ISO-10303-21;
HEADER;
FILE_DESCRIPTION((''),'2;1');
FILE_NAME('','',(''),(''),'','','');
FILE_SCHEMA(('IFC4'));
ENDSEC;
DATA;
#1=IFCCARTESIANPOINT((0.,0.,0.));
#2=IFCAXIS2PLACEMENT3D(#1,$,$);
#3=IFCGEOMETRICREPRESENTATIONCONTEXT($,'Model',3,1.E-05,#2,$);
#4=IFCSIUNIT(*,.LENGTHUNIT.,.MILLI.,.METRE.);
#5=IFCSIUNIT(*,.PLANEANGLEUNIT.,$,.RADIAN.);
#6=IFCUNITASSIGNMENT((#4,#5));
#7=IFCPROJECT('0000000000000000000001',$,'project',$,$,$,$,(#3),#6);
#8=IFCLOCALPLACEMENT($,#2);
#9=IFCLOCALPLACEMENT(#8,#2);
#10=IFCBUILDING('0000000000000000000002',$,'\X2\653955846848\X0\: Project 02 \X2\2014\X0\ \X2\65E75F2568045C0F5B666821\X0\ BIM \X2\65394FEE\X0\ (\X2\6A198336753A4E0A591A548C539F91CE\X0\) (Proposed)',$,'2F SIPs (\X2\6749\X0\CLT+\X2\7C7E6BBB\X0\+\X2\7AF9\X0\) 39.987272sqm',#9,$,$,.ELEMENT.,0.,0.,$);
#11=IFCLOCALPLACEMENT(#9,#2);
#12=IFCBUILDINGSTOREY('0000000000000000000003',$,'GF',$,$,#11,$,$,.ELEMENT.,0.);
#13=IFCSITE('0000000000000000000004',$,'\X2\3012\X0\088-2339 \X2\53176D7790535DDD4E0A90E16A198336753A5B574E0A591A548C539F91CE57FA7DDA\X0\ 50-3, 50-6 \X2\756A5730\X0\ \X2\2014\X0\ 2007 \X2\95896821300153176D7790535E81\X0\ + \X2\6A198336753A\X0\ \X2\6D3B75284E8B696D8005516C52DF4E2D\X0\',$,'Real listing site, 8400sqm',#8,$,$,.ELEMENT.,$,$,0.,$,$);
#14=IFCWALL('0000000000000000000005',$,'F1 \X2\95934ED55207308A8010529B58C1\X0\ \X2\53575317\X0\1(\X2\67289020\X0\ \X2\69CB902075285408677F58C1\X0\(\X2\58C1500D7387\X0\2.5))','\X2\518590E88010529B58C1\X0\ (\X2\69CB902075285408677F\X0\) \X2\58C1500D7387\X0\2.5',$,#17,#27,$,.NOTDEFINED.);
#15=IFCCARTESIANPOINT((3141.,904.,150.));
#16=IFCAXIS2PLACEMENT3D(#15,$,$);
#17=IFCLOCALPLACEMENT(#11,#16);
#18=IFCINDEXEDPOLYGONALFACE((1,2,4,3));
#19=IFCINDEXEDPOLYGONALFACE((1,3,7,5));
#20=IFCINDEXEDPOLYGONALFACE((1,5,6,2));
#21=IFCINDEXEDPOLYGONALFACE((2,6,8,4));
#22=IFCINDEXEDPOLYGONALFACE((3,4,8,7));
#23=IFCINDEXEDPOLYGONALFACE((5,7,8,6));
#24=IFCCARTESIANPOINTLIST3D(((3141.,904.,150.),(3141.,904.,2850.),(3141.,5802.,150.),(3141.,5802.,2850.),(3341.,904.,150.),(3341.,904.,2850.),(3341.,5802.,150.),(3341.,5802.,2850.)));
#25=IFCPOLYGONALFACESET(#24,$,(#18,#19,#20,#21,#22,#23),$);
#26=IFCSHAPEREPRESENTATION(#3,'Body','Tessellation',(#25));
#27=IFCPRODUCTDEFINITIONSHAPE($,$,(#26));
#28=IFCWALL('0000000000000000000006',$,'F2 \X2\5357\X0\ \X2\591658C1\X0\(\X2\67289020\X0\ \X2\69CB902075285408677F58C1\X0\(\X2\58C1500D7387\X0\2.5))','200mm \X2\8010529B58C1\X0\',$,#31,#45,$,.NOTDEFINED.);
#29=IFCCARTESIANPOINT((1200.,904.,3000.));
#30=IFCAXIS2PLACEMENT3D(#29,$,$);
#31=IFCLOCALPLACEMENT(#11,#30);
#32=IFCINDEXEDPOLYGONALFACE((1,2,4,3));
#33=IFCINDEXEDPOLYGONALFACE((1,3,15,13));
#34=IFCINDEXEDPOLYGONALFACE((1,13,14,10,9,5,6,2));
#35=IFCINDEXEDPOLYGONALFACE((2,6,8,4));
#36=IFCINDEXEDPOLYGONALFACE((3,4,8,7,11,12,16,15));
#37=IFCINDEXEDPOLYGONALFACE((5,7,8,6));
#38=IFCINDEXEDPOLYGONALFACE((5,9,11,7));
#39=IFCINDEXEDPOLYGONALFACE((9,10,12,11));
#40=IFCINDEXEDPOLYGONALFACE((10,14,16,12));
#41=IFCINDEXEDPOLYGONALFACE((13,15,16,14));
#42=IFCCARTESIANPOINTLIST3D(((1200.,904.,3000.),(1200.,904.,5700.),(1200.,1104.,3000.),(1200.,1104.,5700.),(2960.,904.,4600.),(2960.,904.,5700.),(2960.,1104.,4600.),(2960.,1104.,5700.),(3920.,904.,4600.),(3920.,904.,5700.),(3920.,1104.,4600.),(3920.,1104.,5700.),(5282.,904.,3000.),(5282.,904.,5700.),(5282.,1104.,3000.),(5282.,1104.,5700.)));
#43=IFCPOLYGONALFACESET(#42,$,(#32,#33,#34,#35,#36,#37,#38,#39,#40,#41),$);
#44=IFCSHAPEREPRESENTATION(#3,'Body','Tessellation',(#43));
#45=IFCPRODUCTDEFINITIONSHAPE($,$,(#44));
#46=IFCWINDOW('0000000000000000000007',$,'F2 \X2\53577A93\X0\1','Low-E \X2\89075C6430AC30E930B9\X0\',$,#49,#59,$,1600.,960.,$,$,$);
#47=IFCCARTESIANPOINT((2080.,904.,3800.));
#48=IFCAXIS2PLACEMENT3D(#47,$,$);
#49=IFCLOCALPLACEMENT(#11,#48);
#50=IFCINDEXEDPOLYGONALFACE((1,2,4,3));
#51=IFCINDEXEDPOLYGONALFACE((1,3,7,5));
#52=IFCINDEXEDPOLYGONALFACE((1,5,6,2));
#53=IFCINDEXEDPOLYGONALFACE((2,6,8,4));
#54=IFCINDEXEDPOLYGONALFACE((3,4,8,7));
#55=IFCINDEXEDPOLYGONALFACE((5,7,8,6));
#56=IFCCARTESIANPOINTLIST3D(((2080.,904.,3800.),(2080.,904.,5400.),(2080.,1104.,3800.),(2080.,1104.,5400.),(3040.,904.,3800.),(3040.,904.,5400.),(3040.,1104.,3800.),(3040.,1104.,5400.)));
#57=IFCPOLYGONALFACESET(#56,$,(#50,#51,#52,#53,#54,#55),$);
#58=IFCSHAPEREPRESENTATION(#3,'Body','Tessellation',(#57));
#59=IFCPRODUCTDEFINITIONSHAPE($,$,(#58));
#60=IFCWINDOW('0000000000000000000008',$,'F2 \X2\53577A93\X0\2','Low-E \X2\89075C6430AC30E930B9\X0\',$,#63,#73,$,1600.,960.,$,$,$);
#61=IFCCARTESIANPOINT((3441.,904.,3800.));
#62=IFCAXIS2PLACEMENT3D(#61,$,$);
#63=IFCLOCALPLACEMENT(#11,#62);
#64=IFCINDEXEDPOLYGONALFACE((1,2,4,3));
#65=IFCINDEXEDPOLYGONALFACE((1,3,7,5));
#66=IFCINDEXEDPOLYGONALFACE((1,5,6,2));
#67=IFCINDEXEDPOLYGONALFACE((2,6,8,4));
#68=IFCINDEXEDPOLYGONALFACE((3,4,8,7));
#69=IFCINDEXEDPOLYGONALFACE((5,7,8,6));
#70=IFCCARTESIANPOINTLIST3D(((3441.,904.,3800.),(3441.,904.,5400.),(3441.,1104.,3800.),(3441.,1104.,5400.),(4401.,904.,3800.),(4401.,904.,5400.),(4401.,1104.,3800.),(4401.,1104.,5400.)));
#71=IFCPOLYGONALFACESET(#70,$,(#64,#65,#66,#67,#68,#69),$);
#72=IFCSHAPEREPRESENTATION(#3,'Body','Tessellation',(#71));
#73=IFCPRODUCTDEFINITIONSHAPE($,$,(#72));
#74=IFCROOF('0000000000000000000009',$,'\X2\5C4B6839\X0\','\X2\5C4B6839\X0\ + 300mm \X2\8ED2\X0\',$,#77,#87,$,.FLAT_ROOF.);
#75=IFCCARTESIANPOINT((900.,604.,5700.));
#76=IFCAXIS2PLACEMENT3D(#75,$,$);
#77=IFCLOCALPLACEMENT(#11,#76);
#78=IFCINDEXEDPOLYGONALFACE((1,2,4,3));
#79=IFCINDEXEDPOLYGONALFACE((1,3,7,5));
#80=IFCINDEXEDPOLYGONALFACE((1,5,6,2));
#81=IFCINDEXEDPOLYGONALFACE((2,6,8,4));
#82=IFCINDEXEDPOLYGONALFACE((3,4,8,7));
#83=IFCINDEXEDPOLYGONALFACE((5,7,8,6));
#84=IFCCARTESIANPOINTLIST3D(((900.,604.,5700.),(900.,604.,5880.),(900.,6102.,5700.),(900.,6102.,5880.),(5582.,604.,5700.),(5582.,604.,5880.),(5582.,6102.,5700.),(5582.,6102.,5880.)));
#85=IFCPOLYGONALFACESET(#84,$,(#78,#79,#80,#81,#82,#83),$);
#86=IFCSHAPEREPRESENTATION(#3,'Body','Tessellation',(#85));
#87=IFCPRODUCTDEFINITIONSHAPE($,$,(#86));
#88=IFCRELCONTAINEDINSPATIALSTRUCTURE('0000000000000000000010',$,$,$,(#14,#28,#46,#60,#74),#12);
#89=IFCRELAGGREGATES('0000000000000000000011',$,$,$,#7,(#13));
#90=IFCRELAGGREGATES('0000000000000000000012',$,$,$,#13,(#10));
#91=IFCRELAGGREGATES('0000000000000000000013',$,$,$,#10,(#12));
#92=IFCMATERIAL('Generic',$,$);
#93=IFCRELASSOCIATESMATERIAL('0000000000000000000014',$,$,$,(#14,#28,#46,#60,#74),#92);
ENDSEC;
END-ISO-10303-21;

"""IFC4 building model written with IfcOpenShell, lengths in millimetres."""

from ifc_helpers import new_model, si_unit, frame, frame_2d, origin, place, context, project, spatial, rectangle, extrude, material, element, fill, save


model = new_model("IFC4")

# Units and contexts
model_context = context("Model", 3, precision=1e-05, world=origin())
ifc_project = project(units=[si_unit("LENGTHUNIT", "METRE", prefix="MILLI"), si_unit("PLANEANGLEUNIT", "RADIAN")], contexts=[model_context])

# Site, building, storey
site_placement = place(None, origin())
site = spatial("IfcSite", under=ifc_project, at=site_placement, Name="〒088-2339 北海道川上郡標茶町字上多和原野基線 50-3, 50-6 番地 — 2007 閉校、北海道庁 + 標茶町 活用事業者公募中", ObjectType="Real listing site, 8400sqm", CompositionType="ELEMENT", RefElevation=0.0)
building_placement = place(site_placement, origin())
building = spatial("IfcBuilding", under=site, at=building_placement, Name="改善案: Project 02 — 旧弥栄小学校 BIM 改修 (標茶町上多和原野) (Proposed)", ObjectType="2F SIPs (杉CLT+籾殻+竹) 39.987272sqm", CompositionType="ELEMENT", ElevationOfRefHeight=0.0, ElevationOfTerrain=0.0)
storey_placement = place(building_placement, origin())
storey = spatial("IfcBuildingStorey", under=building, at=storey_placement, Name="GF", CompositionType="ELEMENT", Elevation=0.0)

# Shared definitions
ifc_material_1 = material(Name="Generic")

# Wall
wall_1_placement = place(storey_placement, frame((3141.0, 904.0, 150.0)))
element("IfcWall", 1, at=wall_1_placement, inside=storey, material=ifc_material_1, Name="F1 間仕切り耐力壁 南北1(木造 構造用合板壁(壁倍率2.5))", Description="内部耐力壁 (構造用合板) 壁倍率2.5", PredefinedType="NOTDEFINED", context=model_context, shape_type="SweptSolid", body=[
    extrude(rectangle(XDim=200.0, YDim=4898.0, at=frame_2d((100.0, 2449.0))), frame((3141.0, 904.0, 150.0)), (0.0, 0.0, 1.0), 2700.0),
])

# Wall, openings, windows
wall_2_placement = place(storey_placement, frame((1200.0, 904.0, 3000.0)))
wall_2 = element("IfcWall", 2, at=wall_2_placement, inside=storey, material=ifc_material_1, Name="F2 南 外壁(木造 構造用合板壁(壁倍率2.5))", Description="200mm 耐力壁", PredefinedType="NOTDEFINED", context=model_context, shape_type="SweptSolid", body=[
    extrude(rectangle(XDim=4082.0, YDim=200.0, at=frame_2d((2041.0, 100.0))), frame((1200.0, 904.0, 3000.0)), (0.0, 0.0, 1.0), 2700.0),
])
opening_1_placement = place(storey_placement, frame((2080.0, 904.0, 3800.0)))
opening_1 = element("IfcOpeningElement", 3, at=opening_1_placement, cuts=wall_2, PredefinedType="NOTDEFINED", context=model_context, shape_type="SweptSolid", body=[
    extrude(rectangle(XDim=960.0, YDim=200.0, at=frame_2d((480.0, 100.0))), frame((2080.0, 904.0, 3800.0)), (0.0, 0.0, 1.0), 1600.0),
])
opening_2_placement = place(storey_placement, frame((3441.0, 904.0, 3800.0)))
opening_2 = element("IfcOpeningElement", 4, at=opening_2_placement, cuts=wall_2, PredefinedType="NOTDEFINED", context=model_context, shape_type="SweptSolid", body=[
    extrude(rectangle(XDim=960.0, YDim=200.0, at=frame_2d((480.0, 100.0))), frame((3441.0, 904.0, 3800.0)), (0.0, 0.0, 1.0), 1600.0),
])
window_1_placement = place(storey_placement, frame((2080.0, 904.0, 3800.0)))
window_1 = element("IfcWindow", 5, at=window_1_placement, inside=storey, material=ifc_material_1, Name="F2 南窓1", Description="Low-E 複層ガラス", OverallHeight=1600.0, OverallWidth=960.0, context=model_context, shape_type="SweptSolid", body=[
    extrude(rectangle(XDim=960.0, YDim=200.0, at=frame_2d((480.0, 100.0))), frame((2080.0, 904.0, 3800.0)), (0.0, 0.0, 1.0), 1600.0),
])
fill(opening_1, window_1)
window_2_placement = place(storey_placement, frame((3441.0, 904.0, 3800.0)))
window_2 = element("IfcWindow", 6, at=window_2_placement, inside=storey, material=ifc_material_1, Name="F2 南窓2", Description="Low-E 複層ガラス", OverallHeight=1600.0, OverallWidth=960.0, context=model_context, shape_type="SweptSolid", body=[
    extrude(rectangle(XDim=960.0, YDim=200.0, at=frame_2d((480.0, 100.0))), frame((3441.0, 904.0, 3800.0)), (0.0, 0.0, 1.0), 1600.0),
])
fill(opening_2, window_2)

# Roof
roof_placement = place(storey_placement, frame((900.0, 604.0, 5700.0)))
element("IfcRoof", 7, at=roof_placement, inside=storey, material=ifc_material_1, Name="屋根", Description="屋根 + 300mm 軒", PredefinedType="FLAT_ROOF", context=model_context, shape_type="SweptSolid", body=[
    extrude(rectangle(XDim=4682.0, YDim=5498.0, at=frame_2d((2341.0, 2749.0))), frame((900.0, 604.0, 5700.0)), (0.0, 0.0, 1.0), 180.0),
])

save(model, "model.ifc")
